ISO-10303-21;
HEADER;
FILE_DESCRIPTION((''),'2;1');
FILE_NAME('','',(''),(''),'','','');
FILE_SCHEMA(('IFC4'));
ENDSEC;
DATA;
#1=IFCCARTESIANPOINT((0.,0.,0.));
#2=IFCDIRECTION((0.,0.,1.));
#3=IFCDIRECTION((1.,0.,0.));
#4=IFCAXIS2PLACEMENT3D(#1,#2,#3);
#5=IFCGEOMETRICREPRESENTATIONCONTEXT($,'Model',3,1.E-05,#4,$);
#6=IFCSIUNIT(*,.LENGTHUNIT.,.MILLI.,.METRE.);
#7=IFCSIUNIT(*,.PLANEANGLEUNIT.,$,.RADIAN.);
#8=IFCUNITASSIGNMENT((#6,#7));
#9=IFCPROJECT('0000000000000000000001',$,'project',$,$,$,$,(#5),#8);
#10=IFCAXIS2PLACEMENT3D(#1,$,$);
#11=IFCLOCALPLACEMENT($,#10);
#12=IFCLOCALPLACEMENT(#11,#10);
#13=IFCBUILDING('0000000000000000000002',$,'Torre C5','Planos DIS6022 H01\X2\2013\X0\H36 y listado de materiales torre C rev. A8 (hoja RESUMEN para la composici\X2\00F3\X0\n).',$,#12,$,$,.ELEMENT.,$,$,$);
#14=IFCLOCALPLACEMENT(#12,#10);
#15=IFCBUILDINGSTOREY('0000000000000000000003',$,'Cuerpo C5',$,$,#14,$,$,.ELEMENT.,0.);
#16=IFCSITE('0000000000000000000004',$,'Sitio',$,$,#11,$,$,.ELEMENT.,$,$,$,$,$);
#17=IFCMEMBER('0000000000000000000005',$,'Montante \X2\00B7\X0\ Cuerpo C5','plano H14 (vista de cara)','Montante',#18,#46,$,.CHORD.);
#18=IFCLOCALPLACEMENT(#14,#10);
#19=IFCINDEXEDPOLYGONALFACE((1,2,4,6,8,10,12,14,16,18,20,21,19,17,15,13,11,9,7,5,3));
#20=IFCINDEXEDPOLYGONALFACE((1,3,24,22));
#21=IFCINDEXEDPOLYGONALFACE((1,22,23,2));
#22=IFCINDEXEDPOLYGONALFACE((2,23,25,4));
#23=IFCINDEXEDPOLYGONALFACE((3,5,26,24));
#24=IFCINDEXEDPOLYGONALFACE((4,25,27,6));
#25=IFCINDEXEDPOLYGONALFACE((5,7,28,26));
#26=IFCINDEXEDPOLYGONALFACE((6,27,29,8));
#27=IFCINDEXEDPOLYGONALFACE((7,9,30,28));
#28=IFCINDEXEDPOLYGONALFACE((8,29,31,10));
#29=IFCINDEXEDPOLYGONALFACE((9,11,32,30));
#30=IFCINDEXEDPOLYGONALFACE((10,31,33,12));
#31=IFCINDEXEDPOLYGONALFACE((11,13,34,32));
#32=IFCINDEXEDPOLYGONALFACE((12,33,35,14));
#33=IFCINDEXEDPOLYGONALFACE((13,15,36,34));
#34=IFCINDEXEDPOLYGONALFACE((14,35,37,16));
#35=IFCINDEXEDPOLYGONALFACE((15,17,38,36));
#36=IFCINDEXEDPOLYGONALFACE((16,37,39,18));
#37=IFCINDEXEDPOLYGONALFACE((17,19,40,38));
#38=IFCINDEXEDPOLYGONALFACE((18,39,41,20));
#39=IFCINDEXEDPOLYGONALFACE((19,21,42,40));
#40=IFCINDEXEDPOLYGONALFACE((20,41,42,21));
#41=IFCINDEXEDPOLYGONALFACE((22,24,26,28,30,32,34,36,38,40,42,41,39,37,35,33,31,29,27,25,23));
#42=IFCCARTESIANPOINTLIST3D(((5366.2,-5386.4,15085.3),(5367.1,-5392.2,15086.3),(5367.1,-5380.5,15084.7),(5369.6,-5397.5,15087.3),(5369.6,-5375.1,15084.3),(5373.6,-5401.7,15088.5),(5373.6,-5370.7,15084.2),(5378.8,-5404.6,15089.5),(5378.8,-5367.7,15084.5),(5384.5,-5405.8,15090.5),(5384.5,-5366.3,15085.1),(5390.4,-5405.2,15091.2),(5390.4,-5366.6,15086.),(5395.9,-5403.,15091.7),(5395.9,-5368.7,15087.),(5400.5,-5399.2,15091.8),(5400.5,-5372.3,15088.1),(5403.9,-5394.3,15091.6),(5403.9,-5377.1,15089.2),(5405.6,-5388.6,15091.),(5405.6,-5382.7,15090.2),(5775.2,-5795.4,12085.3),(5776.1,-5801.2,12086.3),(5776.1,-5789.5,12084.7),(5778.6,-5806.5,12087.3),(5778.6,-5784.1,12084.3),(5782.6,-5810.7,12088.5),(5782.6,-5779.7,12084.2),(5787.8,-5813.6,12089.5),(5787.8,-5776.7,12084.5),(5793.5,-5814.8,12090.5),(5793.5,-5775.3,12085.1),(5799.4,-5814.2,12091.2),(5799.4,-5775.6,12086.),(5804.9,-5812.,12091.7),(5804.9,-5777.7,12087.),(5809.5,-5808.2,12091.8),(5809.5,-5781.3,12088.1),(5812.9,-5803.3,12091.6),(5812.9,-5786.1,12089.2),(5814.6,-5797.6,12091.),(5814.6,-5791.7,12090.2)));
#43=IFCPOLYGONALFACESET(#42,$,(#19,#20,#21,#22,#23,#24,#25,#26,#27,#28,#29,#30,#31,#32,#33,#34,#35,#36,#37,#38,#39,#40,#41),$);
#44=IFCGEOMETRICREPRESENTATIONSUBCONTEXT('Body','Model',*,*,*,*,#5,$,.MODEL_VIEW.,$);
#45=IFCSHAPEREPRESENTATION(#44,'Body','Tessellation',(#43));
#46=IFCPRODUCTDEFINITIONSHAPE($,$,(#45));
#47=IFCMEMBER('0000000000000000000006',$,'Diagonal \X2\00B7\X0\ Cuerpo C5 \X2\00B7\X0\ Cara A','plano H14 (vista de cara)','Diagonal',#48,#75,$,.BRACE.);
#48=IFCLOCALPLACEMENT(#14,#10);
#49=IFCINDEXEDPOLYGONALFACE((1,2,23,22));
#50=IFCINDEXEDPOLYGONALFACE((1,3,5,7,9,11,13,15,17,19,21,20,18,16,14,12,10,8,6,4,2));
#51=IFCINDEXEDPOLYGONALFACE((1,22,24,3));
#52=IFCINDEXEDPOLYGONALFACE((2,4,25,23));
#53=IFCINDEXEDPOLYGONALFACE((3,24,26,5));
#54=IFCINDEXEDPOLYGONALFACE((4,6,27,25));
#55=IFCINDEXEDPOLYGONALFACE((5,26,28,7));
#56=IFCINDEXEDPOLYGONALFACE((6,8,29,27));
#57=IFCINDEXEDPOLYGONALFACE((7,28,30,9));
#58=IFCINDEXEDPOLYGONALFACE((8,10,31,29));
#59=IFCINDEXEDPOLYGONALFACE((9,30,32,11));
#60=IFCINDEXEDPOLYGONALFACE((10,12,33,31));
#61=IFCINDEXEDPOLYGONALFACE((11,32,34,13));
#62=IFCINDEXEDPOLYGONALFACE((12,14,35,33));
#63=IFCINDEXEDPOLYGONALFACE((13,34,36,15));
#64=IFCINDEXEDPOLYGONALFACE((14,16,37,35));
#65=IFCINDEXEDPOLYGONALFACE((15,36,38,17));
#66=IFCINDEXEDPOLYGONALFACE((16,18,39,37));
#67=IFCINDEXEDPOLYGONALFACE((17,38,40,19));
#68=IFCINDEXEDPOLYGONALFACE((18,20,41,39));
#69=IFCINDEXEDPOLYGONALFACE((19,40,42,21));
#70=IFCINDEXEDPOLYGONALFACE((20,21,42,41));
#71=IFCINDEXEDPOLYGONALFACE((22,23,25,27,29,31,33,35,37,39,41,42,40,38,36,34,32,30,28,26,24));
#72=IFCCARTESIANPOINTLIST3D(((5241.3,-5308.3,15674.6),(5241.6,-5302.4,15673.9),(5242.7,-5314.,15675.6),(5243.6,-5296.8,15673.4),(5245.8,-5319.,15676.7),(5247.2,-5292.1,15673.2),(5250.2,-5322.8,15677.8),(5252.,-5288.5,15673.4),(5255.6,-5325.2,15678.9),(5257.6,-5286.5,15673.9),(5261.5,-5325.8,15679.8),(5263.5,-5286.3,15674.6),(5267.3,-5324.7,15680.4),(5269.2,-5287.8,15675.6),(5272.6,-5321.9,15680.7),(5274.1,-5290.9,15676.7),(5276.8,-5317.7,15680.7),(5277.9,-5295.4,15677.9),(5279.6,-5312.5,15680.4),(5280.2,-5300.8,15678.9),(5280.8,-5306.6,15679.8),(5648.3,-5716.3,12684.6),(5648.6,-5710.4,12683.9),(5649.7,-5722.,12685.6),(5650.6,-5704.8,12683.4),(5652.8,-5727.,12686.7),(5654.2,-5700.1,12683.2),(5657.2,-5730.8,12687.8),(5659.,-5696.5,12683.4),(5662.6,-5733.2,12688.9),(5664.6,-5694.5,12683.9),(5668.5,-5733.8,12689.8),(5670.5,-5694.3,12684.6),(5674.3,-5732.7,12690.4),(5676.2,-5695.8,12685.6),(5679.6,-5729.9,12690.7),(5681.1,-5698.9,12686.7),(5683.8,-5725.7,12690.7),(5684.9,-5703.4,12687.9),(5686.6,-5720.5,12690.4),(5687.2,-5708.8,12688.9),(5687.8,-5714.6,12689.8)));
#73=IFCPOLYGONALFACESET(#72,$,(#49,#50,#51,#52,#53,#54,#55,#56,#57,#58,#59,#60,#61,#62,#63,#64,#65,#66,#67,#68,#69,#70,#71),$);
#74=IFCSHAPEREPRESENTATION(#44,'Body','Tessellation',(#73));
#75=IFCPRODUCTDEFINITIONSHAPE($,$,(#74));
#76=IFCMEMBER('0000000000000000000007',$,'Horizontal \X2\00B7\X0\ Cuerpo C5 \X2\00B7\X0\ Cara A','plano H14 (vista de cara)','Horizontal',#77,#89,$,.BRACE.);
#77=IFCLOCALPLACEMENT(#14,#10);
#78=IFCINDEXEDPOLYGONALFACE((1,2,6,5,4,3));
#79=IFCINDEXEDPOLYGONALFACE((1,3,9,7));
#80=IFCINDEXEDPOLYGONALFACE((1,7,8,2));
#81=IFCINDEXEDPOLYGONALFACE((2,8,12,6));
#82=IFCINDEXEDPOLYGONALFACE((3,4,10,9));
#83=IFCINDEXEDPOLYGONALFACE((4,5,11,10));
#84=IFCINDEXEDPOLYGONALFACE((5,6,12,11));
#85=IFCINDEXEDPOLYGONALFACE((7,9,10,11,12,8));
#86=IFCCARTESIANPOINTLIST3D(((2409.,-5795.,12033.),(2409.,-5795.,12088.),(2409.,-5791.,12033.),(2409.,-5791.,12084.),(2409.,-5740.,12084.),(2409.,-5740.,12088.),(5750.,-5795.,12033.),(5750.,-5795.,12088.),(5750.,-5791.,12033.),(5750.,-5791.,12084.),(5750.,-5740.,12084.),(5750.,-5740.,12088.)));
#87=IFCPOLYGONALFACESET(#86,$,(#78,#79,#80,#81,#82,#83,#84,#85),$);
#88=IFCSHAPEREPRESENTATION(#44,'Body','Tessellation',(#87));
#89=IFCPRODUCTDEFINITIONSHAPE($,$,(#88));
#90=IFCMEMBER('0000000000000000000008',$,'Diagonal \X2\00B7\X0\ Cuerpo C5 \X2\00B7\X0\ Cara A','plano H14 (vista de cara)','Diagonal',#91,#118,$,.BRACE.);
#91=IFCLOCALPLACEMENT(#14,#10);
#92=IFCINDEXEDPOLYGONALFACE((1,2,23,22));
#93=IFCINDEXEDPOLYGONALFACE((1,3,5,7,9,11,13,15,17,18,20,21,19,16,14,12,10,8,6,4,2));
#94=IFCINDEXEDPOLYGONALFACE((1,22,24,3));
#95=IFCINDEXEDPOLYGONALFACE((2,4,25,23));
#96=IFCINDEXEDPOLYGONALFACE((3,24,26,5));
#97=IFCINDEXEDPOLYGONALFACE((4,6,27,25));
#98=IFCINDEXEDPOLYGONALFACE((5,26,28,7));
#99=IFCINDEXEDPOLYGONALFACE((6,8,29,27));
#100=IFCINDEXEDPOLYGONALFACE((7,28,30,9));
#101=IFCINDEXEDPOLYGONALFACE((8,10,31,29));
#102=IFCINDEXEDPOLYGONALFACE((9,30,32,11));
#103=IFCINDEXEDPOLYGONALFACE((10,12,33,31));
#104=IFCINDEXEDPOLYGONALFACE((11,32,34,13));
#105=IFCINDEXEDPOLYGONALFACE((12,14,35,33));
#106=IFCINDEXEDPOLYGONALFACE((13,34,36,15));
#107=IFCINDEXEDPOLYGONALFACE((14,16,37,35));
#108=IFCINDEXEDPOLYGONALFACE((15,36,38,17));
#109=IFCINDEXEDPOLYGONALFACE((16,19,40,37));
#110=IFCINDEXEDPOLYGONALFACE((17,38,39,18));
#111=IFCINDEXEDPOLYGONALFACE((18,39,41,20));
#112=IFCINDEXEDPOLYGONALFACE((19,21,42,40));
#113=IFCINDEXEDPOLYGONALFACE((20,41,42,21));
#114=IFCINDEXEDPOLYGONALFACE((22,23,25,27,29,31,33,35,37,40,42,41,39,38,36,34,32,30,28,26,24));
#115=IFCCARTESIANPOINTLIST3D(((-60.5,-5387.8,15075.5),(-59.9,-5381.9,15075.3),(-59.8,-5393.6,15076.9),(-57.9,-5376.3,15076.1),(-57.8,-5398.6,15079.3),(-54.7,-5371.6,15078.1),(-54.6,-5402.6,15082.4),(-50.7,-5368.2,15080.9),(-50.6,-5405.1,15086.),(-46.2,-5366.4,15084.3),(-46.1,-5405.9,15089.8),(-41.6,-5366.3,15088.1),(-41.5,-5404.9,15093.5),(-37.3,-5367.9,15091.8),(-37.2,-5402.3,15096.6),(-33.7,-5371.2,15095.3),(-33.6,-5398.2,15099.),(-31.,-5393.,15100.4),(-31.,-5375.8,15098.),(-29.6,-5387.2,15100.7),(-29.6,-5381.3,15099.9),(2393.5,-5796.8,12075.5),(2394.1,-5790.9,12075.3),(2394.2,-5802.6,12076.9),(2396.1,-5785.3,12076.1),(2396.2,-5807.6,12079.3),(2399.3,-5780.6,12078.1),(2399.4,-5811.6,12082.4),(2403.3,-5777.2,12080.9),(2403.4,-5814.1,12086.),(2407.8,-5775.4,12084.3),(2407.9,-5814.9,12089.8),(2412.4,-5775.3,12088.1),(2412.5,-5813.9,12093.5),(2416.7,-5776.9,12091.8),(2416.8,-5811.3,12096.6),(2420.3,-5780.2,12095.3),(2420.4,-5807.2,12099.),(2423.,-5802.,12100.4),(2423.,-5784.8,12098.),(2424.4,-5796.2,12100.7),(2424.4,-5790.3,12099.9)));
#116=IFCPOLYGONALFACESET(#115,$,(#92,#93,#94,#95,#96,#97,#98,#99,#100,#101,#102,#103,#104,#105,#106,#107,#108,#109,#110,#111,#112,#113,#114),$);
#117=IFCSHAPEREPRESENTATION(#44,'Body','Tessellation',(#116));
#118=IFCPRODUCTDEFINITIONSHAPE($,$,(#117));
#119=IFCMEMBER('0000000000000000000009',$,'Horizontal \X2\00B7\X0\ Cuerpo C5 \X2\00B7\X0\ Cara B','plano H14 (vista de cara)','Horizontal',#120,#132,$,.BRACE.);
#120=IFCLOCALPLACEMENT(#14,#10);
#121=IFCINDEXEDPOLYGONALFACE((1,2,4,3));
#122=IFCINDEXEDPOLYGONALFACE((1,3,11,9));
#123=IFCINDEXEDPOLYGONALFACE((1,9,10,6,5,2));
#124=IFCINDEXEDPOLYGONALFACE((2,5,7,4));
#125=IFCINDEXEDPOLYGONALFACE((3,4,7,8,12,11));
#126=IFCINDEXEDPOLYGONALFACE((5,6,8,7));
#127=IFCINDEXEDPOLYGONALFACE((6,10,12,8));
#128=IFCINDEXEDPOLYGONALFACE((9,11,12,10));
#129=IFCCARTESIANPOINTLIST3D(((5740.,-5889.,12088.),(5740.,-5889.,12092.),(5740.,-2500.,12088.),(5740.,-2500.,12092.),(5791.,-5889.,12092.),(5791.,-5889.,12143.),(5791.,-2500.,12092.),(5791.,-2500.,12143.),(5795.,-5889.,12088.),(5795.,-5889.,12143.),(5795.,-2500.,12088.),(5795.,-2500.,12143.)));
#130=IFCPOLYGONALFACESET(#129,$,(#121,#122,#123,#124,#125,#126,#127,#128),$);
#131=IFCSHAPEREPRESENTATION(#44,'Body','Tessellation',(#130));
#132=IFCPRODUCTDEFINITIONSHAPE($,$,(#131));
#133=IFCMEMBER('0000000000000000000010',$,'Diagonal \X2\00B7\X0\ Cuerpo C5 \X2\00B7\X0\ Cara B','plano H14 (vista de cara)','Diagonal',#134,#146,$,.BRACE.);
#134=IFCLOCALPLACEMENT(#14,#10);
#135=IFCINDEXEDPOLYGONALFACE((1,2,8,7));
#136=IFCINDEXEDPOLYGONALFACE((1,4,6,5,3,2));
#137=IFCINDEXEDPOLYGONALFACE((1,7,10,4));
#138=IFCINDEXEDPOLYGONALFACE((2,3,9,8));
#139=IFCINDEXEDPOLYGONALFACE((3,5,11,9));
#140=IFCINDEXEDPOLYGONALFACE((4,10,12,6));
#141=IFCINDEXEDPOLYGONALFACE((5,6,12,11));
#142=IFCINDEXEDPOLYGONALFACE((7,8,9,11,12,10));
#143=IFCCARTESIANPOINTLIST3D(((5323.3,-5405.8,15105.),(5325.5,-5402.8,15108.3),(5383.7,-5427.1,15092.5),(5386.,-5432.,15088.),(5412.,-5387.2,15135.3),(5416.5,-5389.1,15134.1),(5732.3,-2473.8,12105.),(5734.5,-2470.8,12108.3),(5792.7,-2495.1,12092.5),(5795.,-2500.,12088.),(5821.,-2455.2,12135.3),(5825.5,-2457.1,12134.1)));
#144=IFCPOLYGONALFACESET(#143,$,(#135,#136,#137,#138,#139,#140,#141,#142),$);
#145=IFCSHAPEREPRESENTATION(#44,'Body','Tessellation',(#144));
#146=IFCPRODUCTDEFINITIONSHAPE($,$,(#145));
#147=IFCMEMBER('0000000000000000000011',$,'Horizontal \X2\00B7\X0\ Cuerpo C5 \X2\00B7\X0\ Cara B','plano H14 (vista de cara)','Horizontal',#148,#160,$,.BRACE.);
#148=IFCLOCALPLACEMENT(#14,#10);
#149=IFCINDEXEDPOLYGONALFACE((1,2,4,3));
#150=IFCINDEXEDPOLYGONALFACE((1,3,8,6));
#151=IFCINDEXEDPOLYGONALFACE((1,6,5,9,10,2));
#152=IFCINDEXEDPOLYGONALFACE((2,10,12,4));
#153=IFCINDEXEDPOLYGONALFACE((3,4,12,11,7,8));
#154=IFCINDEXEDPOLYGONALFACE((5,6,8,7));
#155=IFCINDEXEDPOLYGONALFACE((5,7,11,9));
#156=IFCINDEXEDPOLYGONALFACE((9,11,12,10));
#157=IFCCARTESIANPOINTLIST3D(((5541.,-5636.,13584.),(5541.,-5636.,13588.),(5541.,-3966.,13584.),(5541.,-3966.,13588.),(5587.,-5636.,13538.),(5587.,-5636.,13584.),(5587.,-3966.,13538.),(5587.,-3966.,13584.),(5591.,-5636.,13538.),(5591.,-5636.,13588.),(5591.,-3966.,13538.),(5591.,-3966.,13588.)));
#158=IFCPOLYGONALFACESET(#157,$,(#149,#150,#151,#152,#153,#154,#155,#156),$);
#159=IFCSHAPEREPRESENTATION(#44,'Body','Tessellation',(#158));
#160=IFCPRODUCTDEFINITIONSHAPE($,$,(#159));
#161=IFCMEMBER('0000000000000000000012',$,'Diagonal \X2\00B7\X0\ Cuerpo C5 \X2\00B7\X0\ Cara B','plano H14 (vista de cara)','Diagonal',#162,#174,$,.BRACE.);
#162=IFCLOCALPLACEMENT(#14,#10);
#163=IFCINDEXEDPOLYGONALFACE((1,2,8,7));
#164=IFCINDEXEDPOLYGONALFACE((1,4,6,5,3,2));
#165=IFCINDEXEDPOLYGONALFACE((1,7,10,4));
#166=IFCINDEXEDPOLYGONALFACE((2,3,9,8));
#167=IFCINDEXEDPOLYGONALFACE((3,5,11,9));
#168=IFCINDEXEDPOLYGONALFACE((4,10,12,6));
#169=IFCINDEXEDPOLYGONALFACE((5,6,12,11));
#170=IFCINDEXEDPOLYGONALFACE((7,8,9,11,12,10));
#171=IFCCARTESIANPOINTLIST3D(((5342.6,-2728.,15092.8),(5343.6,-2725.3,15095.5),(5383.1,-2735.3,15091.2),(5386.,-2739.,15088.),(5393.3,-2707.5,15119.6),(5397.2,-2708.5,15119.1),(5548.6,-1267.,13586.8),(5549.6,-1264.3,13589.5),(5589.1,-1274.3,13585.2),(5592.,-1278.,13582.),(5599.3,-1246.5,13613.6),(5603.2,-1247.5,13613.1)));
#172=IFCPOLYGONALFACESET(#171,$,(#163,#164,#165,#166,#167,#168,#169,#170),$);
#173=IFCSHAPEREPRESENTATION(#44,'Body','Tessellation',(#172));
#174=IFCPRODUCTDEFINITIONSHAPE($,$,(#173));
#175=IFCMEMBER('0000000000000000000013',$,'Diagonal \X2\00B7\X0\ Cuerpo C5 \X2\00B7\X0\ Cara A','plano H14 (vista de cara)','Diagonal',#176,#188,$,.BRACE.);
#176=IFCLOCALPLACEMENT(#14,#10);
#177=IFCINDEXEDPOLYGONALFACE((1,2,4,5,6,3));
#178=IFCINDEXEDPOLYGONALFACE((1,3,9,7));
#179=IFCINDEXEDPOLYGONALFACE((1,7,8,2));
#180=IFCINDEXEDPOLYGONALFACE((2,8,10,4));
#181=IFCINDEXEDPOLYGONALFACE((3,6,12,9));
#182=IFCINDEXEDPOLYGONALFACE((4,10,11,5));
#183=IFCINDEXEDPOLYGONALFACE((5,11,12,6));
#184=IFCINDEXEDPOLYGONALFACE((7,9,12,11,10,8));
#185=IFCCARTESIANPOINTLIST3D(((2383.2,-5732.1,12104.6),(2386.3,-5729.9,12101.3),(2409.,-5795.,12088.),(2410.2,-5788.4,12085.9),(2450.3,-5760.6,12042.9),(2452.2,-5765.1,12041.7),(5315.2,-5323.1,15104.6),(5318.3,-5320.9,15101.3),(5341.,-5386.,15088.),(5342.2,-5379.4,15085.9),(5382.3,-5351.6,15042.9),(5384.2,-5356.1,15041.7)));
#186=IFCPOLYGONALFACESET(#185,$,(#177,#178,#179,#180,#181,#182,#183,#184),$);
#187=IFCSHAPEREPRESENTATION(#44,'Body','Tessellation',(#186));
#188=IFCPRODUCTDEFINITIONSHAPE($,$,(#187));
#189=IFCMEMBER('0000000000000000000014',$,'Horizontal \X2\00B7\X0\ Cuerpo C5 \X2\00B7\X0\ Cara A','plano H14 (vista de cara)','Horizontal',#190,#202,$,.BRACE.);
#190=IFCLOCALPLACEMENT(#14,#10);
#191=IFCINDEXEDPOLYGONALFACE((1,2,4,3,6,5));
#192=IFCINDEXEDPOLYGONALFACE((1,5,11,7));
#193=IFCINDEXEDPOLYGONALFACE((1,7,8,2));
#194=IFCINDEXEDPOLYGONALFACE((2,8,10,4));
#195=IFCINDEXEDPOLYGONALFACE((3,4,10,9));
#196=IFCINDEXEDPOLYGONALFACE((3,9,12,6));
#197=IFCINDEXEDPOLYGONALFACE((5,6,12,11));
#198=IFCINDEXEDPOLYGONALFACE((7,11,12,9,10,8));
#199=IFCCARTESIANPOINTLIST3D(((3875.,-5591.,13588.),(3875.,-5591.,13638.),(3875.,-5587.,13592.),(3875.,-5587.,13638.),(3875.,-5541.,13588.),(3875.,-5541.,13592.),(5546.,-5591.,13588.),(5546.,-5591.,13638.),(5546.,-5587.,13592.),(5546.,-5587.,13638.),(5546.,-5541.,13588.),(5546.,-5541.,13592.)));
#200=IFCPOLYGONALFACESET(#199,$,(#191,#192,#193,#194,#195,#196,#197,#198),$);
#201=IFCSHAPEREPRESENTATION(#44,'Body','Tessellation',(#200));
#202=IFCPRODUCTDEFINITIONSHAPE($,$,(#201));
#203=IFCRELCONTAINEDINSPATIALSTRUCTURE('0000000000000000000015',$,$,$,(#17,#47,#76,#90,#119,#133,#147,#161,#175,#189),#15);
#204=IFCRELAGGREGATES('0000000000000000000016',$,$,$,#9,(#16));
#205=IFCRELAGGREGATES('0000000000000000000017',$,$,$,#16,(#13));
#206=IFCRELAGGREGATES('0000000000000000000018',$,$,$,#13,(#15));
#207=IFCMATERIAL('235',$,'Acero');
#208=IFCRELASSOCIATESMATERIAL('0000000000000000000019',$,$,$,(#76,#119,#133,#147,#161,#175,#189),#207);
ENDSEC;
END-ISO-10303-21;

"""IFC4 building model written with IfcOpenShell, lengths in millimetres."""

from ifc_helpers import new_model, si_unit, frame, frame_2d, origin, origin_with_axes, place, context, subcontext, project, spatial, circle, l_section, extrude, material, element, save


model = new_model("IFC4")

# Units and contexts
model_context = context("Model", 3, precision=1e-05, world=origin_with_axes())
body_context = subcontext(model_context, "Body", "Model", "MODEL_VIEW")
ifc_project = project(units=[si_unit("LENGTHUNIT", "METRE", prefix="MILLI"), si_unit("PLANEANGLEUNIT", "RADIAN")], contexts=[model_context])

# Site, building, storey
site_placement = place(None, origin())
site = spatial("IfcSite", under=ifc_project, at=site_placement, Name="Sitio", CompositionType="ELEMENT")
building_placement = place(site_placement, origin())
building = spatial("IfcBuilding", under=site, at=building_placement, Name="Torre C5", Description="Planos DIS6022 H01–H36 y listado de materiales torre C rev. A8 (hoja RESUMEN para la composición).", CompositionType="ELEMENT")
storey_placement = place(building_placement, origin())
storey = spatial("IfcBuildingStorey", under=building, at=storey_placement, Name="Cuerpo C5", CompositionType="ELEMENT", Elevation=0.0)

# Members
member_1_placement = place(storey_placement, frame((5386.0, -5386.0, 15088.0), z_axis=(0.133868, -0.133868, -0.981916), x_axis=(-0.990999, -0.018083, -0.132641)))
element("IfcMember", 1, at=member_1_placement, inside=storey, Name="Montante · Cuerpo C5", Description="plano H14 (vista de cara)", ObjectType="Montante", PredefinedType="CHORD", context=body_context, shape_type="SweptSolid", body=[
    extrude(circle(Radius=20.0), None, (0.0, 0.0, 1.0), 3055.3),
])
member_2_placement = place(storey_placement, frame((5668.0, -5714.0, 12687.0), z_axis=(-0.13366, 0.133989, 0.981928), x_axis=(-0.691368, 0.697275, -0.189256)))
element("IfcMember", 2, at=member_2_placement, inside=storey, Name="Diagonal · Cuerpo C5 · Cara A", Description="plano H14 (vista de cara)", ObjectType="Diagonal", PredefinedType="BRACE", context=body_context, shape_type="SweptSolid", body=[
    extrude(circle(Radius=20.0), None, (0.0, 0.0, 1.0), 3045.0),
])
ifc_material_1 = material(Name="235", Category="Acero")
member_3_placement = place(storey_placement, frame((5750.0, -5795.0, 12088.0), z_axis=(-1.0, 0.0, 0.0), x_axis=(0.0, 1.0, 0.0)))
element("IfcMember", 3, at=member_3_placement, inside=storey, material=ifc_material_1, Name="Horizontal · Cuerpo C5 · Cara A", Description="plano H14 (vista de cara)", ObjectType="Horizontal", PredefinedType="BRACE", context=body_context, shape_type="SweptSolid", body=[
    extrude(l_section(Depth=55.0, Width=55.0, Thickness=4.0, at=frame_2d((27.5, 27.5))), None, (0.0, 0.0, 1.0), 3341.0),
])
member_4_placement = place(storey_placement, frame((2409.0, -5795.0, 12088.0), z_axis=(-0.629657, 0.104943, 0.769752), x_axis=(-0.061898, 0.980907, -0.184363)))
element("IfcMember", 4, at=member_4_placement, inside=storey, Name="Diagonal · Cuerpo C5 · Cara A", Description="plano H14 (vista de cara)", ObjectType="Diagonal", PredefinedType="BRACE", context=body_context, shape_type="SweptSolid", body=[
    extrude(circle(Radius=20.0), None, (0.0, 0.0, 1.0), 3897.4),
])
member_5_placement = place(storey_placement, frame((5795.0, -5889.0, 12088.0), z_axis=(0.0, 1.0, 0.0), x_axis=(-1.0, 0.0, 0.0)))
element("IfcMember", 5, at=member_5_placement, inside=storey, material=ifc_material_1, Name="Horizontal · Cuerpo C5 · Cara B", Description="plano H14 (vista de cara)", ObjectType="Horizontal", PredefinedType="BRACE", context=body_context, shape_type="SweptSolid", body=[
    extrude(l_section(Depth=55.0, Width=55.0, Thickness=4.0, at=frame_2d((27.5, 27.5))), None, (0.0, 0.0, 1.0), 3389.0),
])
member_6_placement = place(storey_placement, frame((5386.0, -5432.0, 15088.0), z_axis=(0.097041, 0.695656, -0.71179), x_axis=(-0.895075, 0.373735, 0.243235)))
element("IfcMember", 6, at=member_6_placement, inside=storey, material=ifc_material_1, Name="Diagonal · Cuerpo C5 · Cara B", Description="plano H14 (vista de cara)", ObjectType="Diagonal", PredefinedType="BRACE", context=body_context, shape_type="SweptSolid", body=[
    extrude(l_section(Depth=70.0, Width=70.0, Thickness=5.0, at=frame_2d((35.0, 35.0))), None, (0.0, 0.0, 1.0), 4214.7),
])
member_7_placement = place(storey_placement, frame((5591.0, -3966.0, 13588.0), z_axis=(0.0, -1.0, 0.0), x_axis=(-1.0, 0.0, 0.0)))
element("IfcMember", 7, at=member_7_placement, inside=storey, material=ifc_material_1, Name="Horizontal · Cuerpo C5 · Cara B", Description="plano H14 (vista de cara)", ObjectType="Horizontal", PredefinedType="BRACE", context=body_context, shape_type="SweptSolid", body=[
    extrude(l_section(Depth=50.0, Width=50.0, Thickness=4.0, at=frame_2d((25.0, 25.0))), None, (0.0, 0.0, 1.0), 1670.0),
])
member_8_placement = place(storey_placement, frame((5386.0, -2739.0, 15088.0), z_axis=(0.097708, 0.69297, -0.714314), x_axis=(-0.963786, 0.244839, 0.105691)))
element("IfcMember", 8, at=member_8_placement, inside=storey, material=ifc_material_1, Name="Diagonal · Cuerpo C5 · Cara B", Description="plano H14 (vista de cara)", ObjectType="Diagonal", PredefinedType="BRACE", context=body_context, shape_type="SweptSolid", body=[
    extrude(l_section(Depth=45.0, Width=45.0, Thickness=4.0, at=frame_2d((22.5, 22.5))), None, (0.0, 0.0, 1.0), 2108.3),
])
member_9_placement = place(storey_placement, frame((5341.0, -5386.0, 15088.0), z_axis=(-0.695656, -0.097041, -0.71179), x_axis=(-0.368413, 0.898807, 0.237525)))
element("IfcMember", 9, at=member_9_placement, inside=storey, material=ifc_material_1, Name="Diagonal · Cuerpo C5 · Cara A", Description="plano H14 (vista de cara)", ObjectType="Diagonal", PredefinedType="BRACE", context=body_context, shape_type="SweptSolid", body=[
    extrude(l_section(Depth=70.0, Width=70.0, Thickness=5.0, at=frame_2d((35.0, 35.0))), None, (0.0, 0.0, 1.0), 4214.7),
])
member_10_placement = place(storey_placement, frame((3875.0, -5591.0, 13588.0), z_axis=(1.0, 0.0, 0.0), x_axis=(0.0, 1.0, 0.0)))
element("IfcMember", 10, at=member_10_placement, inside=storey, material=ifc_material_1, Name="Horizontal · Cuerpo C5 · Cara A", Description="plano H14 (vista de cara)", ObjectType="Horizontal", PredefinedType="BRACE", context=body_context, shape_type="SweptSolid", body=[
    extrude(l_section(Depth=50.0, Width=50.0, Thickness=4.0, at=frame_2d((25.0, 25.0))), None, (0.0, 0.0, 1.0), 1671.0),
])

save(model, "model.ifc")
